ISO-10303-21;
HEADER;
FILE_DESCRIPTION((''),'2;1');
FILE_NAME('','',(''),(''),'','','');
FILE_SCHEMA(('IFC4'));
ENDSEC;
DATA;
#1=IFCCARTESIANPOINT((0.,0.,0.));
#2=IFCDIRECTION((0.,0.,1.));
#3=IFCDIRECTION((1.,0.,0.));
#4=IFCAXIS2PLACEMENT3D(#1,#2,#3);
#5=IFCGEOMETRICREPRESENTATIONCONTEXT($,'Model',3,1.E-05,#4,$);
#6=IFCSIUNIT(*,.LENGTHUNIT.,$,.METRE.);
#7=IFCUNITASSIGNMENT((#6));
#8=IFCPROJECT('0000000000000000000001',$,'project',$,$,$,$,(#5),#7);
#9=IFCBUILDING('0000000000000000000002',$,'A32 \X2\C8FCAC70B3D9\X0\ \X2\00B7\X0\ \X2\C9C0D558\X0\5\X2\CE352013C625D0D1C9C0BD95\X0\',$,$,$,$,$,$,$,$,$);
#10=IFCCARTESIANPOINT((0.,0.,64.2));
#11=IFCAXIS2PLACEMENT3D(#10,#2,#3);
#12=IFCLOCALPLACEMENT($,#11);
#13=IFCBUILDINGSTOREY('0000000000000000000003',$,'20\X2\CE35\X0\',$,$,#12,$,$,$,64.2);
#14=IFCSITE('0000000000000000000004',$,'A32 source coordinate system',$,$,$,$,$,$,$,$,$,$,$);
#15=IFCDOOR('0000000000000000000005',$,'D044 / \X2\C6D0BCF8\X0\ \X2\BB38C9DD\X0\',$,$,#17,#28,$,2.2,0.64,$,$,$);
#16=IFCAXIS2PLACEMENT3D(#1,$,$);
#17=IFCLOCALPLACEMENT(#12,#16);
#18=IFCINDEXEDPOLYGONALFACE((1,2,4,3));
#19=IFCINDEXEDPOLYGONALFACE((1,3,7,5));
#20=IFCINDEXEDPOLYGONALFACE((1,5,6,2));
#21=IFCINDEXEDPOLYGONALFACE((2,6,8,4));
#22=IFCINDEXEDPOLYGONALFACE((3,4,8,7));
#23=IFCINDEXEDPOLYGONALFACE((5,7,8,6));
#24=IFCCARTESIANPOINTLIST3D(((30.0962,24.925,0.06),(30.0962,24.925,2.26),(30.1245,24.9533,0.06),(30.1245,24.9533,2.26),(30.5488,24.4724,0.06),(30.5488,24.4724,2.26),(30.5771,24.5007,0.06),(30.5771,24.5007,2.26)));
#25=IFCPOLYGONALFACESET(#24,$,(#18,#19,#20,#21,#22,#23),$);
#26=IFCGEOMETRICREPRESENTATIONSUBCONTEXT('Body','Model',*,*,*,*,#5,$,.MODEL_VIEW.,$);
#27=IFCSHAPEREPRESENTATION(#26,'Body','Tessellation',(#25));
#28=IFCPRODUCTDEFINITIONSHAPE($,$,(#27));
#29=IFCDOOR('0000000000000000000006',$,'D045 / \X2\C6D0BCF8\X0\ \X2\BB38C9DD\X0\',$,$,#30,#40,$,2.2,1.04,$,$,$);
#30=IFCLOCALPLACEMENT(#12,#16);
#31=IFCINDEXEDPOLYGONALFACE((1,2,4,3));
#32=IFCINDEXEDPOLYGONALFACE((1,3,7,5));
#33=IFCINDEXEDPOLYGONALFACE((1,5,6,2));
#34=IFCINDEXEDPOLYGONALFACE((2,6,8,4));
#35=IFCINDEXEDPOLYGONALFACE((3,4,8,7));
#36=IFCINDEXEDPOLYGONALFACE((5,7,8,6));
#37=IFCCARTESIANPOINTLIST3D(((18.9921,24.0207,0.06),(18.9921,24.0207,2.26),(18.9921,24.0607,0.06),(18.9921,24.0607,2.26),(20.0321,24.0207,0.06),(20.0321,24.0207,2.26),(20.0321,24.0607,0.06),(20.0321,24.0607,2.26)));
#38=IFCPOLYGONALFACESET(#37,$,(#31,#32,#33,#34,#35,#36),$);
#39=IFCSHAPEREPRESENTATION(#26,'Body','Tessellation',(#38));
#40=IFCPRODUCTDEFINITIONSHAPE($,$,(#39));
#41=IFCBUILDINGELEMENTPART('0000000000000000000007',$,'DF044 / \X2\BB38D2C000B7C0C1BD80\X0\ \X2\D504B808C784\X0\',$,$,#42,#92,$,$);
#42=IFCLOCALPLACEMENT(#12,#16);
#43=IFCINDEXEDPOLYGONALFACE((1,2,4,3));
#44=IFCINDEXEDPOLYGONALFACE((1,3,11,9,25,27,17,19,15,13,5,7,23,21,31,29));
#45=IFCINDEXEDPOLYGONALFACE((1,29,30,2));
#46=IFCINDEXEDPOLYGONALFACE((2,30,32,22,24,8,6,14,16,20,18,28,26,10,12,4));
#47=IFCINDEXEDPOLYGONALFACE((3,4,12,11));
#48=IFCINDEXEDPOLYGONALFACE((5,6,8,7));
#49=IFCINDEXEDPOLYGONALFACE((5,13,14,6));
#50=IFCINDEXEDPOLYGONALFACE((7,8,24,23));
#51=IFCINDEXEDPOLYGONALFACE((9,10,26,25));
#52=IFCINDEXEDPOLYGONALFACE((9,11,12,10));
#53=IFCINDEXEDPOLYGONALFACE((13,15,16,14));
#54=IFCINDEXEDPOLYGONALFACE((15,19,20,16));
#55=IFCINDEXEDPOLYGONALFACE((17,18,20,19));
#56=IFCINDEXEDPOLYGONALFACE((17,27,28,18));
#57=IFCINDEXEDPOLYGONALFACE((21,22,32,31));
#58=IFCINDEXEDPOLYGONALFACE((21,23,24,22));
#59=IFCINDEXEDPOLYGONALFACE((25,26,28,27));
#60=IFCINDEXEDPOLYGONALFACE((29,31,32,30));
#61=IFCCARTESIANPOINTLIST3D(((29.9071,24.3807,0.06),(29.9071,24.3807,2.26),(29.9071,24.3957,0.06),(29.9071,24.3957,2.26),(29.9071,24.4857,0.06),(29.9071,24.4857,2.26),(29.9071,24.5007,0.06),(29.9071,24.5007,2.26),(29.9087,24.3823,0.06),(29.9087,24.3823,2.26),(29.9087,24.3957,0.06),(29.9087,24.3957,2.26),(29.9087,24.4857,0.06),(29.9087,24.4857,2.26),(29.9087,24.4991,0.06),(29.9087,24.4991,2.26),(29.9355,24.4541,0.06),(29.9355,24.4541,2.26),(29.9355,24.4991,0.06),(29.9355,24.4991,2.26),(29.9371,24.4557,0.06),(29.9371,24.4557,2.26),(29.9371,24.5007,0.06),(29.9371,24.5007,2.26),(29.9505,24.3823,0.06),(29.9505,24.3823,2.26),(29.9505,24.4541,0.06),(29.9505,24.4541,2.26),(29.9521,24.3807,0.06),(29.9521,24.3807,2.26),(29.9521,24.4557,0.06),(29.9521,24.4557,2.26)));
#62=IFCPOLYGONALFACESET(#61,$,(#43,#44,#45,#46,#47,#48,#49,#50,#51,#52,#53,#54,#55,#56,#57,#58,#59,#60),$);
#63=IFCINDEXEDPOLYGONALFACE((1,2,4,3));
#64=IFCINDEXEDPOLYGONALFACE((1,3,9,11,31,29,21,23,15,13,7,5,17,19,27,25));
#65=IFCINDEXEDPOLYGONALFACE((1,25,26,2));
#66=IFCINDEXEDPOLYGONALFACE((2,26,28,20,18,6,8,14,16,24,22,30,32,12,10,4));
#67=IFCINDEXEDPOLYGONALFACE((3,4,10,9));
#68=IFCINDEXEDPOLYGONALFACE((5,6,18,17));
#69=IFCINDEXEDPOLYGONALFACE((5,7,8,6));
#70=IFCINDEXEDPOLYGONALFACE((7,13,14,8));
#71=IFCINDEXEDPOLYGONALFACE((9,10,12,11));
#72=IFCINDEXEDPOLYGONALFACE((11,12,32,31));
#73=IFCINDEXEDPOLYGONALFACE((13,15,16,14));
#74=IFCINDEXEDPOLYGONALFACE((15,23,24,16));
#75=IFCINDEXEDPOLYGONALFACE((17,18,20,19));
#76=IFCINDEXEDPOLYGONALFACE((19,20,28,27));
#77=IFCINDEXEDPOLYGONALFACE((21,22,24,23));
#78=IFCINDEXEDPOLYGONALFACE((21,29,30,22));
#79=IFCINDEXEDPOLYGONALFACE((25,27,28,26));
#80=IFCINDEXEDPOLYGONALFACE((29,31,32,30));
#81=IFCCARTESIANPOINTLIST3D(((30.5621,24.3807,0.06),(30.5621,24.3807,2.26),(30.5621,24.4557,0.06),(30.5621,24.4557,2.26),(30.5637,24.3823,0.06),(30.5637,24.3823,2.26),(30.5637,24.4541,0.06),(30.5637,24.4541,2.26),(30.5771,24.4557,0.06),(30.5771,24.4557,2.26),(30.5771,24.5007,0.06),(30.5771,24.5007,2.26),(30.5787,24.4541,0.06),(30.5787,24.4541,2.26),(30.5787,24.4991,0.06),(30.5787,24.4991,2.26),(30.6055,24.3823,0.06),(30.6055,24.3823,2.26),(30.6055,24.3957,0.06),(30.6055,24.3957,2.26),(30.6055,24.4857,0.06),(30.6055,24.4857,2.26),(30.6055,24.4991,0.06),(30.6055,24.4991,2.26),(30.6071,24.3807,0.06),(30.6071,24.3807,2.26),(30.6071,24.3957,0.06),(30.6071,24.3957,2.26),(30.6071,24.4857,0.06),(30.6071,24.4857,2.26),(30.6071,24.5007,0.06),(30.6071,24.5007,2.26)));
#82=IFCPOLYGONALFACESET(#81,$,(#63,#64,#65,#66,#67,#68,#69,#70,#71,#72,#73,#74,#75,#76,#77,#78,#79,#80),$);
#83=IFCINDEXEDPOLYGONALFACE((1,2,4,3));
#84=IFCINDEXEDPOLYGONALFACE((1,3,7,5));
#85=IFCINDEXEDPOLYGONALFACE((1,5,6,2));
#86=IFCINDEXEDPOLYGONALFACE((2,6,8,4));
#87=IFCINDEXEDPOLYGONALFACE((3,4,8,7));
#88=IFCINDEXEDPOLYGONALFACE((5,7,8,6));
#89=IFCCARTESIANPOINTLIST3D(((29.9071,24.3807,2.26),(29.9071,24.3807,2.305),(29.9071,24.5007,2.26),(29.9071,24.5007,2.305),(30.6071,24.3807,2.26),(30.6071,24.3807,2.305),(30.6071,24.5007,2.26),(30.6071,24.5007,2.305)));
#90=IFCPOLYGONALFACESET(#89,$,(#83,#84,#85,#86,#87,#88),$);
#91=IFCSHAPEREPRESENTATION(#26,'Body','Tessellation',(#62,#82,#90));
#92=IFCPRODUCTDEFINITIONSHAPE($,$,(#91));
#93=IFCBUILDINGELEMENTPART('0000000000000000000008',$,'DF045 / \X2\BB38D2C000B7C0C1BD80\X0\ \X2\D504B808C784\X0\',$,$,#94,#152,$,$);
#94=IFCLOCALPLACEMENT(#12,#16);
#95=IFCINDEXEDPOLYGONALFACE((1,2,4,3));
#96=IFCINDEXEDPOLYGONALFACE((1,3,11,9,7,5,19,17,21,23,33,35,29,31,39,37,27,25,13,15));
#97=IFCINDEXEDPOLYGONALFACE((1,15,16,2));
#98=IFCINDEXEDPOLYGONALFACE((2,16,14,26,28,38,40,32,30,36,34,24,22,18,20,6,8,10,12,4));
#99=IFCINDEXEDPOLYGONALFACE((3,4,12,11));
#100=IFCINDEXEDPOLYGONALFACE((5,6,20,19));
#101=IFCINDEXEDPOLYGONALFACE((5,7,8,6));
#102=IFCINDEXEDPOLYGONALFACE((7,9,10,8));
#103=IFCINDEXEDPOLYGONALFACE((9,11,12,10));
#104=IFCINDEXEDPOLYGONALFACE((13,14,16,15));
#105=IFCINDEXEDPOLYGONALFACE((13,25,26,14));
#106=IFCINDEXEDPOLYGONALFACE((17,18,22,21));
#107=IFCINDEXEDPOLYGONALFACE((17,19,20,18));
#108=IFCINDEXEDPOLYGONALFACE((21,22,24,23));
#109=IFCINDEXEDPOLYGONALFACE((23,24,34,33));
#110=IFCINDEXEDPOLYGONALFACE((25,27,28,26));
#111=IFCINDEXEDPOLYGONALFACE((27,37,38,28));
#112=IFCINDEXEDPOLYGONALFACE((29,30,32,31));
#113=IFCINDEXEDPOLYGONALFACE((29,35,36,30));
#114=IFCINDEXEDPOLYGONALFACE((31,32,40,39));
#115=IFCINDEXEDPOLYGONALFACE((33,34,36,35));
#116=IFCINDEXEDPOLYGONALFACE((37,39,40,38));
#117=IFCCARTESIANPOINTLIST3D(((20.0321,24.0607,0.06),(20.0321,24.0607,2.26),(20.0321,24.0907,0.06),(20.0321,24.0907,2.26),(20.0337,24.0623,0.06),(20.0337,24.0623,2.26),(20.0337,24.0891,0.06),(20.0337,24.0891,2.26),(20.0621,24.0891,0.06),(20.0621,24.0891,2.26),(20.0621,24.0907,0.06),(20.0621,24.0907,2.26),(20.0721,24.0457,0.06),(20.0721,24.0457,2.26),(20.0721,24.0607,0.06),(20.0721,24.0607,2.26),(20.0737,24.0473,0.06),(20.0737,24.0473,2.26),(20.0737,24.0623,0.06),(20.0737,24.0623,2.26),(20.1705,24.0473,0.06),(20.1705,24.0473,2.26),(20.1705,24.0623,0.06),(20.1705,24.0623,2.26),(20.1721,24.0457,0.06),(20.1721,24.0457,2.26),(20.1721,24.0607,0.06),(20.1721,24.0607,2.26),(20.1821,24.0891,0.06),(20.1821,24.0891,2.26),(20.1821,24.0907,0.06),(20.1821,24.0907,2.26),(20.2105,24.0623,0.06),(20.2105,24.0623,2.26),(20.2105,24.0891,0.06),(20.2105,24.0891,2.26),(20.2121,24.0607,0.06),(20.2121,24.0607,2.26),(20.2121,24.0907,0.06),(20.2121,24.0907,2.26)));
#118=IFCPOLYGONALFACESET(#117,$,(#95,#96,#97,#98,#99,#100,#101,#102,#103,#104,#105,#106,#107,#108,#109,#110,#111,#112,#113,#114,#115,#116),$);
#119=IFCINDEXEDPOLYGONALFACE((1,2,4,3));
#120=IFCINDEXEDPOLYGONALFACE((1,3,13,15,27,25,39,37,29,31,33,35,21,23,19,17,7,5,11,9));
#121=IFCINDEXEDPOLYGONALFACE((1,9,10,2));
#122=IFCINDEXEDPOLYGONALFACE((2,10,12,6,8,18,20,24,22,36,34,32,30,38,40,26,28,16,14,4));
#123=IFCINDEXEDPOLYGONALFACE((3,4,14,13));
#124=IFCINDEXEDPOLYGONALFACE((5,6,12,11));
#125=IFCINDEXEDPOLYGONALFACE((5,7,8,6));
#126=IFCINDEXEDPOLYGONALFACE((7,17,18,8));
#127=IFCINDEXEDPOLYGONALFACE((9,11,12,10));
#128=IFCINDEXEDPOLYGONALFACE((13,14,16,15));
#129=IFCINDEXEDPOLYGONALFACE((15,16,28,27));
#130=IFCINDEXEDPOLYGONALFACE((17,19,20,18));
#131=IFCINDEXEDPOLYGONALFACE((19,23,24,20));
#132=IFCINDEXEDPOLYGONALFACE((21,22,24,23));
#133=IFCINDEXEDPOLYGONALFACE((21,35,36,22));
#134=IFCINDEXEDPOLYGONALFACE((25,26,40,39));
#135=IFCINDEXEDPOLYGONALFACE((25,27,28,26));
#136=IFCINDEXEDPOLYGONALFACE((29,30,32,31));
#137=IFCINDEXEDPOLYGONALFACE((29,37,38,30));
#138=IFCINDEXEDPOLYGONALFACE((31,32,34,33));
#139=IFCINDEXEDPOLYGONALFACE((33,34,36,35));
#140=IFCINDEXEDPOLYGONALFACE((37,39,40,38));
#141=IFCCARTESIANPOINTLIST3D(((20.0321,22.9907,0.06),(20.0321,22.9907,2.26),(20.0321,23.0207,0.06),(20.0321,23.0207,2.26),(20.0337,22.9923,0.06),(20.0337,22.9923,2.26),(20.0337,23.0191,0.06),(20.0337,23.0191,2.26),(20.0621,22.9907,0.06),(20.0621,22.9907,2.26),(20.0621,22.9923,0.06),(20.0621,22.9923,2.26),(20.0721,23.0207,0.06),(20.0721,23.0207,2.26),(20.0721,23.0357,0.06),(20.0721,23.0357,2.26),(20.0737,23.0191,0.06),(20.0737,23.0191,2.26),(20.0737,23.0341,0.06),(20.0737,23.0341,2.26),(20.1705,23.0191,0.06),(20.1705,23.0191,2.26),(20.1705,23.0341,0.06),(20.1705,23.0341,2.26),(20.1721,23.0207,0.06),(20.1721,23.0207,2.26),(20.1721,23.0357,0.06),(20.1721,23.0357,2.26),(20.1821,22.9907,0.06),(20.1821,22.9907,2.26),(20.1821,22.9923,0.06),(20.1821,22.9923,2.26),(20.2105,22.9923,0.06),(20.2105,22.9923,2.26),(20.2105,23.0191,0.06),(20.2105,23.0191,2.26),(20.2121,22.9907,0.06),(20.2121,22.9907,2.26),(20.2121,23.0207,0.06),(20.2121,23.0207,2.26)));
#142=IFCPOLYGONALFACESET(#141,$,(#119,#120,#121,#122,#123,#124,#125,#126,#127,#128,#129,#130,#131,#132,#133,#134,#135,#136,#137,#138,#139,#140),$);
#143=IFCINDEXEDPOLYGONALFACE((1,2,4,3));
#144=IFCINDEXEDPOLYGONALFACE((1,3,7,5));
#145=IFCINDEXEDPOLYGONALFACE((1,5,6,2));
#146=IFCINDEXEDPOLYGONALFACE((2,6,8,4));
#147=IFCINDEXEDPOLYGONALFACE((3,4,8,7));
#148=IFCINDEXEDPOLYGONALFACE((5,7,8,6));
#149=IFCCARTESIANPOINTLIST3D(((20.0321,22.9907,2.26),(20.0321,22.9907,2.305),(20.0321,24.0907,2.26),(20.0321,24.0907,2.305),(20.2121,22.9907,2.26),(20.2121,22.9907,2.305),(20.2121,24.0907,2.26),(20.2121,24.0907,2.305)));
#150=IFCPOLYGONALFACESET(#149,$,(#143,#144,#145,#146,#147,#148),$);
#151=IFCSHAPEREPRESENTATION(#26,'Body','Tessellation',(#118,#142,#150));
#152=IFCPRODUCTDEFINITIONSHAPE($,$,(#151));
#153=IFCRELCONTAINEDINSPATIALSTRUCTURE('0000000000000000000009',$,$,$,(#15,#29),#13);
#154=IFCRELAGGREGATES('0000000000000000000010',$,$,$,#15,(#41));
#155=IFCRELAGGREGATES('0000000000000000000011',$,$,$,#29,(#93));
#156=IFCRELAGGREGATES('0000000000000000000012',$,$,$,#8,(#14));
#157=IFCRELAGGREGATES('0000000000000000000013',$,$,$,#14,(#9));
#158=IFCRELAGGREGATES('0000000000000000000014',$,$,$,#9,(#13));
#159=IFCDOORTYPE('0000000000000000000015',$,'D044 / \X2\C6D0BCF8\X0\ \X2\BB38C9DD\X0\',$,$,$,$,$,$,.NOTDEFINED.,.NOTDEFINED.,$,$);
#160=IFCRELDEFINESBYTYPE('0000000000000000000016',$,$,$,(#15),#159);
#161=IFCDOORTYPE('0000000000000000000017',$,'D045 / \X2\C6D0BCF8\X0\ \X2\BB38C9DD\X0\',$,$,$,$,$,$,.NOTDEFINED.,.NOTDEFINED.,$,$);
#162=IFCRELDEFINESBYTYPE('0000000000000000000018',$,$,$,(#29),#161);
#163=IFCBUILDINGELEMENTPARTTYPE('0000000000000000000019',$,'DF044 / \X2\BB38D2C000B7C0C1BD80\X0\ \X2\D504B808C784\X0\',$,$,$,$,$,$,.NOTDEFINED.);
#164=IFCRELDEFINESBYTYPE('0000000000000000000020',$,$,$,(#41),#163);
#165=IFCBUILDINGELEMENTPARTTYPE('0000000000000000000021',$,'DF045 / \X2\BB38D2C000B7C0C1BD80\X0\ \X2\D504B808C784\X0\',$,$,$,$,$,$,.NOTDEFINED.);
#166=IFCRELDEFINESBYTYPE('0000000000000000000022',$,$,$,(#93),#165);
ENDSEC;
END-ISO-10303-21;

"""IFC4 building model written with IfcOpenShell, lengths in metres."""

from ifc_helpers import new_model, si_unit, frame, origin, origin_with_axes, place, context, subcontext, project, spatial, polyline, outline, extrude, source, transform, mapped, type_object, type_shapes, element, aggregate, save


model = new_model("IFC4")

# Units and contexts
model_context = context("Model", 3, precision=1e-05, world=origin_with_axes())
body_context = subcontext(model_context, "Body", "Model", "MODEL_VIEW")
ifc_project = project(units=[si_unit("LENGTHUNIT", "METRE")], contexts=[model_context])

# Site, building, storey
storey_placement = place(None, frame((0.0, 0.0, 64.2), z_axis=(0.0, 0.0, 1.0), x_axis=(1.0, 0.0, 0.0)))
site = spatial("IfcSite", under=ifc_project, Name="A32 source coordinate system")
building = spatial("IfcBuilding", under=site, Name="A32 주거동 · 지하5층–옥탑지붕")
storey = spatial("IfcBuildingStorey", under=building, at=storey_placement, Name="20층", Elevation=64.2)

# Doors
door_type_1 = type_object("IfcDoorType", Name="D044 / 원본 문짝", OperationType="NOTDEFINED", PredefinedType="NOTDEFINED")
shared_shape_1 = source(origin(), body_context, "Body", "SweptSolid", [
    extrude(outline(polyline([(30.5771, 24.5007), (30.5488, 24.4724), (30.0962, 24.925), (30.1245, 24.9533), (30.5771, 24.5007)])), frame((0.0, 0.0, 0.06)), (0.0, 0.0, 1.0), 2.2),
])
type_shapes(door_type_1, [shared_shape_1])
door_1_placement = place(storey_placement, origin_with_axes())
door_1 = element("IfcDoor", 1, at=door_1_placement, inside=storey, type_object=door_type_1, Name="D044 / 원본 문짝", OverallHeight=2.2, OverallWidth=0.64, context=body_context, shape_type="MappedRepresentation", body=[
    mapped(shared_shape_1, transform((0.0, 0.0, 0.0), scale=1.0)),
])
door_type_2 = type_object("IfcDoorType", Name="D045 / 원본 문짝", OperationType="NOTDEFINED", PredefinedType="NOTDEFINED")
shared_shape_2 = source(origin(), body_context, "Body", "SweptSolid", [
    extrude(outline(polyline([(20.0321, 24.0607), (20.0321, 24.0207), (18.9921, 24.0207), (18.9921, 24.0607), (20.0321, 24.0607)])), frame((0.0, 0.0, 0.06)), (0.0, 0.0, 1.0), 2.2),
])
type_shapes(door_type_2, [shared_shape_2])
door_2_placement = place(storey_placement, origin_with_axes())
door_2 = element("IfcDoor", 2, at=door_2_placement, inside=storey, type_object=door_type_2, Name="D045 / 원본 문짝", OverallHeight=2.2, OverallWidth=1.04, context=body_context, shape_type="MappedRepresentation", body=[
    mapped(shared_shape_2, transform((0.0, 0.0, 0.0), scale=1.0)),
])

# Building element parts
building_element_part_type_1 = type_object("IfcBuildingElementPartType", Name="DF044 / 문틀·상부 프레임", PredefinedType="NOTDEFINED")
shared_shape_3 = source(origin(), body_context, "Body", "SweptSolid", [
    extrude(outline(polyline([(29.9071, 24.4857), (29.9071, 24.5007), (29.9371, 24.5007), (29.9371, 24.4557), (29.9521, 24.4557), (29.9521, 24.3807), (29.9071, 24.3807), (29.9071, 24.3957), (29.9087, 24.3957), (29.9087, 24.3823), (29.9505, 24.3823), (29.9505, 24.4541), (29.9355, 24.4541), (29.9355, 24.4991), (29.9087, 24.4991), (29.9087, 24.4857), (29.9071, 24.4857)])), frame((0.0, 0.0, 0.06)), (0.0, 0.0, 1.0), 2.2),
    extrude(outline(polyline([(30.6055, 24.4991), (30.5787, 24.4991), (30.5787, 24.4541), (30.5637, 24.4541), (30.5637, 24.3823), (30.6055, 24.3823), (30.6055, 24.3957), (30.6071, 24.3957), (30.6071, 24.3807), (30.5621, 24.3807), (30.5621, 24.4557), (30.5771, 24.4557), (30.5771, 24.5007), (30.6071, 24.5007), (30.6071, 24.4857), (30.6055, 24.4857), (30.6055, 24.4991)])), frame((0.0, 0.0, 0.06)), (0.0, 0.0, 1.0), 2.2),
    extrude(outline(polyline([(29.9071, 24.3807), (29.9071, 24.5007), (30.6071, 24.5007), (30.6071, 24.3807), (29.9071, 24.3807)])), frame((0.0, 0.0, 2.26)), (0.0, 0.0, 1.0), 0.045),
])
type_shapes(building_element_part_type_1, [shared_shape_3])
building_element_part_1_placement = place(door_1_placement, origin_with_axes())
building_element_part_1 = element("IfcBuildingElementPart", 3, at=building_element_part_1_placement, type_object=building_element_part_type_1, Name="DF044 / 문틀·상부 프레임", context=body_context, shape_type="MappedRepresentation", body=[
    mapped(shared_shape_3, transform((0.0, 0.0, 0.0), scale=1.0)),
])
aggregate(door_1, [building_element_part_1])
building_element_part_type_2 = type_object("IfcBuildingElementPartType", Name="DF045 / 문틀·상부 프레임", PredefinedType="NOTDEFINED")
shared_shape_4 = source(origin(), body_context, "Body", "SweptSolid", [
    extrude(outline(polyline([(20.0337, 24.0891), (20.0337, 24.0623), (20.0737, 24.0623), (20.0737, 24.0473), (20.1705, 24.0473), (20.1705, 24.0623), (20.2105, 24.0623), (20.2105, 24.0891), (20.1821, 24.0891), (20.1821, 24.0907), (20.2121, 24.0907), (20.2121, 24.0607), (20.1721, 24.0607), (20.1721, 24.0457), (20.0721, 24.0457), (20.0721, 24.0607), (20.0321, 24.0607), (20.0321, 24.0907), (20.0621, 24.0907), (20.0621, 24.0891), (20.0337, 24.0891)])), frame((0.0, 0.0, 0.06)), (0.0, 0.0, 1.0), 2.2),
    extrude(outline(polyline([(20.0621, 22.9907), (20.0321, 22.9907), (20.0321, 23.0207), (20.0721, 23.0207), (20.0721, 23.0357), (20.1721, 23.0357), (20.1721, 23.0207), (20.2121, 23.0207), (20.2121, 22.9907), (20.1821, 22.9907), (20.1821, 22.9923), (20.2105, 22.9923), (20.2105, 23.0191), (20.1705, 23.0191), (20.1705, 23.0341), (20.0737, 23.0341), (20.0737, 23.0191), (20.0337, 23.0191), (20.0337, 22.9923), (20.0621, 22.9923), (20.0621, 22.9907)])), frame((0.0, 0.0, 0.06)), (0.0, 0.0, 1.0), 2.2),
    extrude(outline(polyline([(20.0321, 22.9907), (20.0321, 24.0907), (20.2121, 24.0907), (20.2121, 22.9907), (20.0321, 22.9907)])), frame((0.0, 0.0, 2.26)), (0.0, 0.0, 1.0), 0.045),
])
type_shapes(building_element_part_type_2, [shared_shape_4])
building_element_part_2_placement = place(door_2_placement, origin_with_axes())
building_element_part_2 = element("IfcBuildingElementPart", 4, at=building_element_part_2_placement, type_object=building_element_part_type_2, Name="DF045 / 문틀·상부 프레임", context=body_context, shape_type="MappedRepresentation", body=[
    mapped(shared_shape_4, transform((0.0, 0.0, 0.0), scale=1.0)),
])
aggregate(door_2, [building_element_part_2])

save(model, "model.ifc")
